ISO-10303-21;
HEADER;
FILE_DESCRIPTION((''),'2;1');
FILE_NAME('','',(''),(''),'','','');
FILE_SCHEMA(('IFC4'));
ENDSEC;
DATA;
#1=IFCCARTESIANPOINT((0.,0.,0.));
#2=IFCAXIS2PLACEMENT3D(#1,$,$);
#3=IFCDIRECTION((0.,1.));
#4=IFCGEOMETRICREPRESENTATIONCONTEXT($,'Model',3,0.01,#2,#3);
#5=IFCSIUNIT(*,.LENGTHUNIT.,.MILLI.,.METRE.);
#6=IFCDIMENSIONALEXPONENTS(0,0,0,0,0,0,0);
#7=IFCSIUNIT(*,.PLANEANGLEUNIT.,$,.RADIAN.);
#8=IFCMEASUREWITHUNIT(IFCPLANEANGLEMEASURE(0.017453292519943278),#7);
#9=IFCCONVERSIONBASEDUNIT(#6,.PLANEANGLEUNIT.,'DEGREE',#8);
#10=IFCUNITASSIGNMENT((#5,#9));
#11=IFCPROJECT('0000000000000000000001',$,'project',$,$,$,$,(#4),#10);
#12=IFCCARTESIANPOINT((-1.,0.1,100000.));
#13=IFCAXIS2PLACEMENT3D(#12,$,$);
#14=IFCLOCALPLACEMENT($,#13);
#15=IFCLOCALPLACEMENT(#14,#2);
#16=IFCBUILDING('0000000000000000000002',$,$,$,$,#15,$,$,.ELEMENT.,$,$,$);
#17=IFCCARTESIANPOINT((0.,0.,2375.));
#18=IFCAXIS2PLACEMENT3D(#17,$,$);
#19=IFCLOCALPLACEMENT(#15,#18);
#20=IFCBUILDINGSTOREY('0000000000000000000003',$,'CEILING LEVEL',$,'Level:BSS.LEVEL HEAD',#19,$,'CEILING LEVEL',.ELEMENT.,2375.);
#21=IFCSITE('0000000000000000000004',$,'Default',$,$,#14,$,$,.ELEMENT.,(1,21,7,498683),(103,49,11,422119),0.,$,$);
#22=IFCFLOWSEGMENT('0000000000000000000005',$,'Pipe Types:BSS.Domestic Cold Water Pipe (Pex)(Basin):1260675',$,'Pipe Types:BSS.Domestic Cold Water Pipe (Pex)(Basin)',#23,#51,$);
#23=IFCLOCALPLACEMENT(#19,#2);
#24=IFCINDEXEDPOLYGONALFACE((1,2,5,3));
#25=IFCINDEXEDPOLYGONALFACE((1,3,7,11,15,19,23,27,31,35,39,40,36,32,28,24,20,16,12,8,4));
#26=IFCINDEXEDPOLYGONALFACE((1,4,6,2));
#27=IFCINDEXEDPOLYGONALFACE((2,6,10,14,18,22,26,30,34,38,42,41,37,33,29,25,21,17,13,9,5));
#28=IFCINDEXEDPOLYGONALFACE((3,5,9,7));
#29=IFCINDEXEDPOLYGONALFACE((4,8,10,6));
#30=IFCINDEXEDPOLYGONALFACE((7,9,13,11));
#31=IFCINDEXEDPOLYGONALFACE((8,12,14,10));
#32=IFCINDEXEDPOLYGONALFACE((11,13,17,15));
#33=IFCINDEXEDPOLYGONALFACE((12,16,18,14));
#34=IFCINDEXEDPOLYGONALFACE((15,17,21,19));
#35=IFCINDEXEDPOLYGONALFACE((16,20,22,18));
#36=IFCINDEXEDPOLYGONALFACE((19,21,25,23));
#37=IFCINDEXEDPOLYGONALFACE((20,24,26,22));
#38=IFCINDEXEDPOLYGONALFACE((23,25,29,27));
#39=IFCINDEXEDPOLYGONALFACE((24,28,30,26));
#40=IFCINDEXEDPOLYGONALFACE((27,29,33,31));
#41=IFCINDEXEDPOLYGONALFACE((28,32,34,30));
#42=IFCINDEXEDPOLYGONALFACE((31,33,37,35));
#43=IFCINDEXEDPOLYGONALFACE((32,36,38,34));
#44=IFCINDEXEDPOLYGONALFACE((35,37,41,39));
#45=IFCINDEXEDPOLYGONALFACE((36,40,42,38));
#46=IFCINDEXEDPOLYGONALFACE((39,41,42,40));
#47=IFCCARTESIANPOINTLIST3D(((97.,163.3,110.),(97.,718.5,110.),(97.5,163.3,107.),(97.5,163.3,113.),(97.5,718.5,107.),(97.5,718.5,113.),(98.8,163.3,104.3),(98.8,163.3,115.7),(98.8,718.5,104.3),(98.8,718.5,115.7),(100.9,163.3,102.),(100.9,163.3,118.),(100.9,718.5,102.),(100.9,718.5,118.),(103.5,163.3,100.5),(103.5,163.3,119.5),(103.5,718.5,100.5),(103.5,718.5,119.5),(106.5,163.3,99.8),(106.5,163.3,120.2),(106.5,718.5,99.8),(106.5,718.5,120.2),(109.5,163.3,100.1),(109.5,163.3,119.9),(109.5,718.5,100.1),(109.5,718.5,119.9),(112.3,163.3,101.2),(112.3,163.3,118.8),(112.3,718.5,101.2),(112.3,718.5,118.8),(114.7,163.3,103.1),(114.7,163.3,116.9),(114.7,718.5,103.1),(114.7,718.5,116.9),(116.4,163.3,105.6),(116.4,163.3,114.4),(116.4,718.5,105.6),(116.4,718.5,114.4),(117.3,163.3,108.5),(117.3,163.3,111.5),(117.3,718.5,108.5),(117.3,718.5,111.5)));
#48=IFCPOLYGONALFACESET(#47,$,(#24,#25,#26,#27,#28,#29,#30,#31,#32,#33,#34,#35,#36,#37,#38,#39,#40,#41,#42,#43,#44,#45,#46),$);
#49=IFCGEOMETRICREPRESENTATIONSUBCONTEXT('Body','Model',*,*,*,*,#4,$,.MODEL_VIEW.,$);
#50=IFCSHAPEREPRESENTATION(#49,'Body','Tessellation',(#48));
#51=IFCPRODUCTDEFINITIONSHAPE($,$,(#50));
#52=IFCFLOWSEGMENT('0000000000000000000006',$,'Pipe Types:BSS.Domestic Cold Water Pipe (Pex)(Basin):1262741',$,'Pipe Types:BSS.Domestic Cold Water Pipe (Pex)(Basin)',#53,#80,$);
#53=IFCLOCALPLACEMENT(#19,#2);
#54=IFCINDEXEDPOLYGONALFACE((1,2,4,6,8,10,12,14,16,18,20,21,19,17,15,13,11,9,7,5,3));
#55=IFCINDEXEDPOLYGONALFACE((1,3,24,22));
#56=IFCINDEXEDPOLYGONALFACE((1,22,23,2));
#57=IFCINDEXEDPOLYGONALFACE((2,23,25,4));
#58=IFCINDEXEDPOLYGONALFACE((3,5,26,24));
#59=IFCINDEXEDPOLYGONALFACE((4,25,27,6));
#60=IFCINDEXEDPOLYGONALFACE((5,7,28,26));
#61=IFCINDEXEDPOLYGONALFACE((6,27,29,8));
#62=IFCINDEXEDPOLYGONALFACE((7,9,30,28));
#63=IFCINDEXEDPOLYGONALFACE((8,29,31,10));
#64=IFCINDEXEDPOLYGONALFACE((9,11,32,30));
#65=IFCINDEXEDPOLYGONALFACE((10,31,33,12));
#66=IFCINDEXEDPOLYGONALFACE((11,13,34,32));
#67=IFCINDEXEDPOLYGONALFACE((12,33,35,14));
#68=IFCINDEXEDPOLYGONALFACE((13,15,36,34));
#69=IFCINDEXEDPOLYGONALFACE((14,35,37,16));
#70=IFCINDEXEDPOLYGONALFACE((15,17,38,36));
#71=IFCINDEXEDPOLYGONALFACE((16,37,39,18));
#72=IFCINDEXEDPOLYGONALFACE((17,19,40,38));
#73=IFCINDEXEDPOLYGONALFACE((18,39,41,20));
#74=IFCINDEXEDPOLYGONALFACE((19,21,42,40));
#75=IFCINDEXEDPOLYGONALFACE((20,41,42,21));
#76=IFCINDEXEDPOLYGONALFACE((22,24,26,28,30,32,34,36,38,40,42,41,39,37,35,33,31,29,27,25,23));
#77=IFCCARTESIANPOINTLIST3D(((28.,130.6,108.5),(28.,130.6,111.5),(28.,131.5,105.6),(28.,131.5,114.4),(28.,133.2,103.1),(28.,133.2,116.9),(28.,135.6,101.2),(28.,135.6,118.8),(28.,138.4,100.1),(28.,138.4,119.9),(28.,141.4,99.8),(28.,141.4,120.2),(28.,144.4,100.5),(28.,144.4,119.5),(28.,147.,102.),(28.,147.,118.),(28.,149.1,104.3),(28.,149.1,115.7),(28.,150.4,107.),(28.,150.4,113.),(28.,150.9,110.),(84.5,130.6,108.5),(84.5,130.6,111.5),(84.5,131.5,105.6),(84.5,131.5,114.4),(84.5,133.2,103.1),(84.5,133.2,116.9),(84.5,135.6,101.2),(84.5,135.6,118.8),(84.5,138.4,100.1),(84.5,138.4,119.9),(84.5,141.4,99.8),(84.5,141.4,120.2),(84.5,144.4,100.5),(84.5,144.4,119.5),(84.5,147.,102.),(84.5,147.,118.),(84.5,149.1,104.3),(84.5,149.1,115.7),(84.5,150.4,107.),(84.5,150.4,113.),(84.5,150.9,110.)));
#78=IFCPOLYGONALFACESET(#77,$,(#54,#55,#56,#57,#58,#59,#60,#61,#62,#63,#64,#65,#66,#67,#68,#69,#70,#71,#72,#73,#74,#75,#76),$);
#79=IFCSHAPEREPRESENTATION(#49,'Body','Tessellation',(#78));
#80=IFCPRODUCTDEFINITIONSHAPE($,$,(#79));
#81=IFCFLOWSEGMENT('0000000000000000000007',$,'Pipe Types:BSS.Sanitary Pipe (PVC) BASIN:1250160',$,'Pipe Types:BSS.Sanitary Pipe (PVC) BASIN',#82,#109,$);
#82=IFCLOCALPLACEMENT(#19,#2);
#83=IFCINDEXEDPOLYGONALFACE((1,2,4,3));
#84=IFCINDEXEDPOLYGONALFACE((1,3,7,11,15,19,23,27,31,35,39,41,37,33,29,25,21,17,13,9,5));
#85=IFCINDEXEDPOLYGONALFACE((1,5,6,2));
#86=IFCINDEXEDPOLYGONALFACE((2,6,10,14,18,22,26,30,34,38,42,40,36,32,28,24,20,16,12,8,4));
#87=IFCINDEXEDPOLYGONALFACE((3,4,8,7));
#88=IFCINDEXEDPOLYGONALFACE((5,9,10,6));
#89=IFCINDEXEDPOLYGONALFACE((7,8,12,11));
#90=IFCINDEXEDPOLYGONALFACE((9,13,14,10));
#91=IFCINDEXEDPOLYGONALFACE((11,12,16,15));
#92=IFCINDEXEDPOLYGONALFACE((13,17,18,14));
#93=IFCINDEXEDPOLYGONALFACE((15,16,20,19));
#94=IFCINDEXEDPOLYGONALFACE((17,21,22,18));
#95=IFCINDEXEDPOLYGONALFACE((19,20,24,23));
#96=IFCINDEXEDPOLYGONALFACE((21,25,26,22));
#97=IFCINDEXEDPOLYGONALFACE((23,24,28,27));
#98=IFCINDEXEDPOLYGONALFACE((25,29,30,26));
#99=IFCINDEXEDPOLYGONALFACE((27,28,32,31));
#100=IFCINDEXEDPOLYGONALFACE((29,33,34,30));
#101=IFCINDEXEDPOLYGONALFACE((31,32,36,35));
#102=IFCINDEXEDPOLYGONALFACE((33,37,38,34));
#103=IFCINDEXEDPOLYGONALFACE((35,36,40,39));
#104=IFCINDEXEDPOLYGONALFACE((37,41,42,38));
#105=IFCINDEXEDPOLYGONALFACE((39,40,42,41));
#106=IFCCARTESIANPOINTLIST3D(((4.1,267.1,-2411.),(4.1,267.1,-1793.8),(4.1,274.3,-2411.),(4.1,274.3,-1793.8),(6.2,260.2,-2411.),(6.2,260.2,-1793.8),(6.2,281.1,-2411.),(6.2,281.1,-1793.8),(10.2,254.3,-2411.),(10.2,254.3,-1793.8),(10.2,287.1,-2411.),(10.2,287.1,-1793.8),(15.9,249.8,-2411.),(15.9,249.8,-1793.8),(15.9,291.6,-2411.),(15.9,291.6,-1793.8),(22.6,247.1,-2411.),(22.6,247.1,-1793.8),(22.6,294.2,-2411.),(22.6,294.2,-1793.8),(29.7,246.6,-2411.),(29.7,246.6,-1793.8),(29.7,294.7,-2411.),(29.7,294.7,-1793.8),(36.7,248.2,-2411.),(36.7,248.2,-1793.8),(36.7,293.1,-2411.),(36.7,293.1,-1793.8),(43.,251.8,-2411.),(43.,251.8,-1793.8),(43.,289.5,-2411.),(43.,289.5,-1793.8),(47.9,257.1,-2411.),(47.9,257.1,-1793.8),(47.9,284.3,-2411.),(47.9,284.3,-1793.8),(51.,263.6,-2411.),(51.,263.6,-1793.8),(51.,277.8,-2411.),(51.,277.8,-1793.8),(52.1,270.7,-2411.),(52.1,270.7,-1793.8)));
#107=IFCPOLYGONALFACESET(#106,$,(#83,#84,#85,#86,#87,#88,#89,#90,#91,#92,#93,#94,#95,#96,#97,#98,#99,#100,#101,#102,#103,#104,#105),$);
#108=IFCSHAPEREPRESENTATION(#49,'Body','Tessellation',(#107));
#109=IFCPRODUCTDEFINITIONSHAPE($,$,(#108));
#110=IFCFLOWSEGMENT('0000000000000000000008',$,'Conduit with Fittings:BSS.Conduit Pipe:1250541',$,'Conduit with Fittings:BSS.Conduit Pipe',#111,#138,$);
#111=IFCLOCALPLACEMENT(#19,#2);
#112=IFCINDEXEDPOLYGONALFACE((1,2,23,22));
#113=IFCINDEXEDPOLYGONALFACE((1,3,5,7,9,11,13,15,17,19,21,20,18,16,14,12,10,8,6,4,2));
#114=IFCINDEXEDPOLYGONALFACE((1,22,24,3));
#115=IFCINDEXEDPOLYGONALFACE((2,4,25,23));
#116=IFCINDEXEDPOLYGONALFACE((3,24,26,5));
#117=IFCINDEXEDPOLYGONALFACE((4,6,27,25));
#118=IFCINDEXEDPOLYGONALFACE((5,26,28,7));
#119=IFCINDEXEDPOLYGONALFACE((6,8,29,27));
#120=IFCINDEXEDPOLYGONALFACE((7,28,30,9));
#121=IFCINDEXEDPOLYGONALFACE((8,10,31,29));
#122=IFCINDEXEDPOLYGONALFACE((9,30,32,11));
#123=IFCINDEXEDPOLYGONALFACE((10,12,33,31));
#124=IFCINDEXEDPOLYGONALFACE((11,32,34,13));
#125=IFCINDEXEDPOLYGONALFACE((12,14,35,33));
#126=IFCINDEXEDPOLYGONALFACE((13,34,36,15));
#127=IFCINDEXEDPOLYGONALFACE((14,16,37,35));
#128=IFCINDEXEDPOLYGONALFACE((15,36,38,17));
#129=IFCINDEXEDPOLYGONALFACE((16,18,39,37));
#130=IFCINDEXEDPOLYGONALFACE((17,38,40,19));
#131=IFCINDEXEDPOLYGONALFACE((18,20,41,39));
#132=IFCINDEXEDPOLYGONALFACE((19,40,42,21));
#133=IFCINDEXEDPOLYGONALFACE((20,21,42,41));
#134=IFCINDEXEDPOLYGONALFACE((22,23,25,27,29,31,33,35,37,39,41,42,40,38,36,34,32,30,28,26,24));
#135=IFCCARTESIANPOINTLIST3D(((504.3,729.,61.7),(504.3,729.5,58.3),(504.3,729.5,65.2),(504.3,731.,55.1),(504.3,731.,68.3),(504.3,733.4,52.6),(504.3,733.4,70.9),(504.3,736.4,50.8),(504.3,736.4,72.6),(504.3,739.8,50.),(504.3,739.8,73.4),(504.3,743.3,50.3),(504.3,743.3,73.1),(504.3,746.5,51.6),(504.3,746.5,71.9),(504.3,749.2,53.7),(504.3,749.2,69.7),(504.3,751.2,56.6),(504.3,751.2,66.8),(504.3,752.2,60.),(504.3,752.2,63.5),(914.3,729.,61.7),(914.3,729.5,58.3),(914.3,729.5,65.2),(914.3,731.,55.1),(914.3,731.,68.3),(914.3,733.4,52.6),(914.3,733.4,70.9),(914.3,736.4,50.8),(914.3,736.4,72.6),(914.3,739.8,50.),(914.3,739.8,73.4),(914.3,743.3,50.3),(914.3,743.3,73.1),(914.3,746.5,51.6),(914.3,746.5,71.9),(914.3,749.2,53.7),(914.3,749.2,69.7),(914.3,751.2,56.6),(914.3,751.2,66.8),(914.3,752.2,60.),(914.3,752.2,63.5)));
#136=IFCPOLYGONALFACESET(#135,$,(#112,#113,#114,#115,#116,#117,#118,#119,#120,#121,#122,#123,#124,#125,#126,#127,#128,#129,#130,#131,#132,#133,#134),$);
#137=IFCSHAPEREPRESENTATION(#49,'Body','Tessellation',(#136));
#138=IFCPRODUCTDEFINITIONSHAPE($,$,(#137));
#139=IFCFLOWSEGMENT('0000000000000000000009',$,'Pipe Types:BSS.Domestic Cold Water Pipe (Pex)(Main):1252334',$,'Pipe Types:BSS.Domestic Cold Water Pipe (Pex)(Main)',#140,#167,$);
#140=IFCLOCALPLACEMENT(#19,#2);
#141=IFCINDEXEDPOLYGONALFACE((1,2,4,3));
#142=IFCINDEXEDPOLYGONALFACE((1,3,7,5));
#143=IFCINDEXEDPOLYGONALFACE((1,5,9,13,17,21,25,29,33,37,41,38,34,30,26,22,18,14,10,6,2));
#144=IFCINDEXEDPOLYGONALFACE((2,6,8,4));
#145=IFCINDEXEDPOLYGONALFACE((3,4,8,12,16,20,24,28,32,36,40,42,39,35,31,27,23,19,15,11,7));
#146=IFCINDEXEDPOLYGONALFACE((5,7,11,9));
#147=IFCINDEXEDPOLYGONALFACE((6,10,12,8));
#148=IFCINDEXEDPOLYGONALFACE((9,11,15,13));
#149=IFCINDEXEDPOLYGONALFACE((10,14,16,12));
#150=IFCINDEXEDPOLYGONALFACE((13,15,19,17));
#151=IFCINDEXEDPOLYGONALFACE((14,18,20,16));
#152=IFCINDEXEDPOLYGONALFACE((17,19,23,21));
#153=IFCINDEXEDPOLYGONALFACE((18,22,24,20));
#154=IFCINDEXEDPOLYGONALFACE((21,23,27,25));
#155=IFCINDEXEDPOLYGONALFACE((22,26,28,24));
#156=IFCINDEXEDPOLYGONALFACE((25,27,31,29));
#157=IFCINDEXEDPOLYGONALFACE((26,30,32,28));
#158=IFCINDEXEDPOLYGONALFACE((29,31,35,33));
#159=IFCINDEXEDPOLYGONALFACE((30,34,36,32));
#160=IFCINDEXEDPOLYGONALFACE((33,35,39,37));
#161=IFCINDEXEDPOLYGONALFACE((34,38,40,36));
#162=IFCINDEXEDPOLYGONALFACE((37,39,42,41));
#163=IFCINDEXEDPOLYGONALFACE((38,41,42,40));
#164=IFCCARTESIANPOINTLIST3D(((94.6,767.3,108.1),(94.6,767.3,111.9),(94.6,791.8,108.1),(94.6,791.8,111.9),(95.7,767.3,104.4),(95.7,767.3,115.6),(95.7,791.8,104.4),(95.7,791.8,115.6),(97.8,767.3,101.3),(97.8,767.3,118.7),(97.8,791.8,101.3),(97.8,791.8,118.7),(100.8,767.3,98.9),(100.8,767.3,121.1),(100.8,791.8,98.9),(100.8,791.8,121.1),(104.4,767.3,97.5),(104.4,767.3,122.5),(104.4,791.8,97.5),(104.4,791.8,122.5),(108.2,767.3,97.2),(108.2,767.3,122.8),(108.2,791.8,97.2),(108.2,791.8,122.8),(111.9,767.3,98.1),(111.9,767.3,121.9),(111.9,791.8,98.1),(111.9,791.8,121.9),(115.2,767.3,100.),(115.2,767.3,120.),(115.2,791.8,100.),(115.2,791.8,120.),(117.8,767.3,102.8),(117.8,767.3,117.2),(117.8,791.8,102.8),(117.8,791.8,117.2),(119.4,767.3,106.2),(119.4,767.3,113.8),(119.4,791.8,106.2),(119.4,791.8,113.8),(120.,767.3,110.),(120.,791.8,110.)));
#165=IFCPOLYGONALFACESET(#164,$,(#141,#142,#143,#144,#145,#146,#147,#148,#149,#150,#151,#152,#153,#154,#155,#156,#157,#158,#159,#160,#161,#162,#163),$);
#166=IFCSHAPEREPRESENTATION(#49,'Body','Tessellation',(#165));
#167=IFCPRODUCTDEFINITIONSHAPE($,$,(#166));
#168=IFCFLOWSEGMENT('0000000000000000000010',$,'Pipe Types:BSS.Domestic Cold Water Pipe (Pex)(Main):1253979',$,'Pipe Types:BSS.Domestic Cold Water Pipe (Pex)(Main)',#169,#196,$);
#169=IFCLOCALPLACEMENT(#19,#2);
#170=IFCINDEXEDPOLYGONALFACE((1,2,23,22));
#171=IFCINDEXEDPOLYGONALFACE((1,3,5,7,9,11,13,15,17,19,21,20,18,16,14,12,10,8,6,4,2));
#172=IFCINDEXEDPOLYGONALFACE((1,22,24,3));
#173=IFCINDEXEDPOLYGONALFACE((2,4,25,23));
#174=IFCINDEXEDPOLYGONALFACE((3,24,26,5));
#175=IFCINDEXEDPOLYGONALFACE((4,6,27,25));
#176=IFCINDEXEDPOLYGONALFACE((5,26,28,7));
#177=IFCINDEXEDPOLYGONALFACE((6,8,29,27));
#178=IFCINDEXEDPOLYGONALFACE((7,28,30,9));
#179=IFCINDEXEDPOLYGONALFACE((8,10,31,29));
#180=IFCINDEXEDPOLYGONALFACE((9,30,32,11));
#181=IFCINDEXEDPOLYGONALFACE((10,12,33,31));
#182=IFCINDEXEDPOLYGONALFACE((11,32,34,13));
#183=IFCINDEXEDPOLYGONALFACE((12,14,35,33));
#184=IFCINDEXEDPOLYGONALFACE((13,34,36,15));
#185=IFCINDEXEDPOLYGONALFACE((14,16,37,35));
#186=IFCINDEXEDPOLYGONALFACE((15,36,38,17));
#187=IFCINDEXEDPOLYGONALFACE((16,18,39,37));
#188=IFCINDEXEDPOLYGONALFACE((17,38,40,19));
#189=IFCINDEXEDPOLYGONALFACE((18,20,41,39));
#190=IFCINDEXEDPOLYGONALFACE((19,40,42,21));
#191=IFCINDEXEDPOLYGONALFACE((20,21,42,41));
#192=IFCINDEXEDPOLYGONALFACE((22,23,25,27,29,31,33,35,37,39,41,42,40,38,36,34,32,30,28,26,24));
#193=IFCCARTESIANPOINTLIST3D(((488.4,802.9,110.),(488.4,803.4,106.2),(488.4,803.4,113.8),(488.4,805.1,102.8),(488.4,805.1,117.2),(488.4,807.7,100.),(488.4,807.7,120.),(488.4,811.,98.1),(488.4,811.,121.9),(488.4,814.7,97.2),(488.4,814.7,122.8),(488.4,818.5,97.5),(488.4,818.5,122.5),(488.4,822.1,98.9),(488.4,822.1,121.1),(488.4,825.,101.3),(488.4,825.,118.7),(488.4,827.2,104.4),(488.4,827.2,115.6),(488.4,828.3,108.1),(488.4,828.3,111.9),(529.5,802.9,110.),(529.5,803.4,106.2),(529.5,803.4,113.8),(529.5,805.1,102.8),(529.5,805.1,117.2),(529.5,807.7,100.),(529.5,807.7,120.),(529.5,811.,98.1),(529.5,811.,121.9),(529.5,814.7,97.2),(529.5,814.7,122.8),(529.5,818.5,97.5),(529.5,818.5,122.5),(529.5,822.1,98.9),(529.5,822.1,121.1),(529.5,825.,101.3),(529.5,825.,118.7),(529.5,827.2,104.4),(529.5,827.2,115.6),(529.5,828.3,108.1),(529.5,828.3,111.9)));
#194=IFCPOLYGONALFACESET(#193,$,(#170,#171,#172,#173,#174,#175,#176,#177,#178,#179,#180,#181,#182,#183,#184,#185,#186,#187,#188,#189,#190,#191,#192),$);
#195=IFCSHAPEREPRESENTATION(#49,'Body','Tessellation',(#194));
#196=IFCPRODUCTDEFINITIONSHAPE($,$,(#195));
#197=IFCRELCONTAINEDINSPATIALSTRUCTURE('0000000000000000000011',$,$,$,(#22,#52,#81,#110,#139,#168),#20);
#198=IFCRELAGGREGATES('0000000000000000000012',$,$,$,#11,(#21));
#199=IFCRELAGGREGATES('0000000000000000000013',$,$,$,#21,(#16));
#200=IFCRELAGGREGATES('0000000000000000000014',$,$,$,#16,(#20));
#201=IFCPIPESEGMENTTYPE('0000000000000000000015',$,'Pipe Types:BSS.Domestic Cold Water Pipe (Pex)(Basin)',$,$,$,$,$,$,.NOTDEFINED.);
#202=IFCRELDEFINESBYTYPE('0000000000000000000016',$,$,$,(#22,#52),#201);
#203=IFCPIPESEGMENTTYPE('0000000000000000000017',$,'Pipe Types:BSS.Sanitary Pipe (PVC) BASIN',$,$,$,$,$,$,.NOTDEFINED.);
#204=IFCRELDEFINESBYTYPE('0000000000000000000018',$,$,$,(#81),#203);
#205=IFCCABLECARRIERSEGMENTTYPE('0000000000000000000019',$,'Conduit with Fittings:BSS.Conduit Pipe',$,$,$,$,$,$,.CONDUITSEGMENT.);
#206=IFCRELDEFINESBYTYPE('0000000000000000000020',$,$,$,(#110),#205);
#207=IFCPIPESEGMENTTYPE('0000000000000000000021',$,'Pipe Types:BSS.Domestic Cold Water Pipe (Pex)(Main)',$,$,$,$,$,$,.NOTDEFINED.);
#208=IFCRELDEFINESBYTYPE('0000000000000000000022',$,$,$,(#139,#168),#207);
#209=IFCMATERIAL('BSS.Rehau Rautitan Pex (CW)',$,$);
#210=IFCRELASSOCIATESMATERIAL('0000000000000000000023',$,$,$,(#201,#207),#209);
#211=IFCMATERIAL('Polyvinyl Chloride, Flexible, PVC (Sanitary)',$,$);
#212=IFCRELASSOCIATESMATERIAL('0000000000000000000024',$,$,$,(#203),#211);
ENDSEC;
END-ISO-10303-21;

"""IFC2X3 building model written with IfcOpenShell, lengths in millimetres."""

from ifc_helpers import new_model, entity, si_unit, converted_unit, direction, frame, frame_2d, origin, place, context, subcontext, project, spatial, circle, extrude, material, type_object, element, save


model = new_model("IFC2X3")

# Units and contexts
model_context = context("Model", 3, precision=0.01, world=origin(), true_north=direction((0.0, 1.0)))
body_context = subcontext(model_context, "Body", "Model", "MODEL_VIEW")
ifc_project = project(units=[si_unit("LENGTHUNIT", "METRE", prefix="MILLI"), converted_unit("PLANEANGLEUNIT", "DEGREE", entity("IfcPlaneAngleMeasure", 0.017453292519943278), si_unit("PLANEANGLEUNIT", "RADIAN"), dimensions=[0, 0, 0, 0, 0, 0, 0])], contexts=[model_context])

# Site, building, storey
site_placement = place(None, frame((-1.0, 0.1, 100000.0)))
site = spatial("IfcSite", under=ifc_project, at=site_placement, Name="Default", CompositionType="ELEMENT", RefLatitude=(1, 21, 7, 498683), RefLongitude=(103, 49, 11, 422119), RefElevation=0.0)
building_placement = place(site_placement, origin())
building = spatial("IfcBuilding", under=site, at=building_placement, CompositionType="ELEMENT")
storey_placement = place(building_placement, frame((0.0, 0.0, 2375.0)))
storey = spatial("IfcBuildingStorey", under=building, at=storey_placement, Name="CEILING LEVEL", ObjectType="Level:BSS.LEVEL HEAD", LongName="CEILING LEVEL", CompositionType="ELEMENT", Elevation=2375.0)

# Flow segments
ifc_material_1 = material(Name="BSS.Rehau Rautitan Pex (CW)")
pipe_segment_type_1 = type_object("IfcPipeSegmentType", Name="Pipe Types:BSS.Domestic Cold Water Pipe (Pex)(Basin)", PredefinedType="NOTDEFINED", material=ifc_material_1)
flow_segment_1_placement = place(storey_placement, origin())
element("IfcFlowSegment", 1, at=flow_segment_1_placement, inside=storey, type_object=pipe_segment_type_1, Name="Pipe Types:BSS.Domestic Cold Water Pipe (Pex)(Basin):1260675", ObjectType="Pipe Types:BSS.Domestic Cold Water Pipe (Pex)(Basin)", context=body_context, shape_type="SweptSolid", body=[
    extrude(circle(Radius=10.2, at=frame_2d((0.0, 0.0), x_axis=(1.0, 0.0))), frame((107.2, 163.3, 110.0), z_axis=(0.0, 1.0, 0.0), x_axis=(-1.0, 0.0, 0.0)), (0.0, 0.0, 1.0), 555.2),
])
flow_segment_2_placement = place(storey_placement, origin())
element("IfcFlowSegment", 2, at=flow_segment_2_placement, inside=storey, type_object=pipe_segment_type_1, Name="Pipe Types:BSS.Domestic Cold Water Pipe (Pex)(Basin):1262741", ObjectType="Pipe Types:BSS.Domestic Cold Water Pipe (Pex)(Basin)", context=body_context, shape_type="SweptSolid", body=[
    extrude(circle(Radius=10.2, at=frame_2d((0.0, 0.0), x_axis=(1.0, 0.0))), frame((28.0, 140.7, 110.0), z_axis=(1.0, 0.0, 0.0), x_axis=(0.0, 1.0, 0.0)), (0.0, 0.0, 1.0), 56.5),
])
ifc_material_2 = material(Name="Polyvinyl Chloride, Flexible, PVC (Sanitary)")
pipe_segment_type_2 = type_object("IfcPipeSegmentType", Name="Pipe Types:BSS.Sanitary Pipe (PVC) BASIN", PredefinedType="NOTDEFINED", material=ifc_material_2)
flow_segment_3_placement = place(storey_placement, origin())
element("IfcFlowSegment", 3, at=flow_segment_3_placement, inside=storey, type_object=pipe_segment_type_2, Name="Pipe Types:BSS.Sanitary Pipe (PVC) BASIN:1250160", ObjectType="Pipe Types:BSS.Sanitary Pipe (PVC) BASIN", context=body_context, shape_type="SweptSolid", body=[
    extrude(circle(Radius=24.1, at=frame_2d((0.0, 0.0), x_axis=(1.0, 0.0))), frame((27.9, 270.7, -2411.0)), (0.0, 0.0, 1.0), 617.2),
])
cable_carrier_segment_type = type_object("IfcCableCarrierSegmentType", Name="Conduit with Fittings:BSS.Conduit Pipe", PredefinedType="CONDUITSEGMENT")
flow_segment_4_placement = place(storey_placement, origin())
element("IfcFlowSegment", 4, at=flow_segment_4_placement, inside=storey, type_object=cable_carrier_segment_type, Name="Conduit with Fittings:BSS.Conduit Pipe:1250541", ObjectType="Conduit with Fittings:BSS.Conduit Pipe", context=body_context, shape_type="SweptSolid", body=[
    extrude(circle(Radius=11.7, at=frame_2d((0.0, 0.0), x_axis=(1.0, 0.0))), frame((504.3, 740.7, 61.7), z_axis=(1.0, 0.0, 0.0), x_axis=(0.0, -1.0, 0.0)), (0.0, 0.0, 1.0), 410.0),
])
pipe_segment_type_3 = type_object("IfcPipeSegmentType", Name="Pipe Types:BSS.Domestic Cold Water Pipe (Pex)(Main)", PredefinedType="NOTDEFINED", material=ifc_material_1)
flow_segment_5_placement = place(storey_placement, origin())
element("IfcFlowSegment", 5, at=flow_segment_5_placement, inside=storey, type_object=pipe_segment_type_3, Name="Pipe Types:BSS.Domestic Cold Water Pipe (Pex)(Main):1252334", ObjectType="Pipe Types:BSS.Domestic Cold Water Pipe (Pex)(Main)", context=body_context, shape_type="SweptSolid", body=[
    extrude(circle(Radius=12.8, at=frame_2d((0.0, 0.0), x_axis=(1.0, 0.0))), frame((107.2, 767.3, 110.0), z_axis=(0.0, 1.0, 0.0), x_axis=(1.0, 0.0, 0.0)), (0.0, 0.0, 1.0), 24.5),
])
flow_segment_6_placement = place(storey_placement, origin())
element("IfcFlowSegment", 6, at=flow_segment_6_placement, inside=storey, type_object=pipe_segment_type_3, Name="Pipe Types:BSS.Domestic Cold Water Pipe (Pex)(Main):1253979", ObjectType="Pipe Types:BSS.Domestic Cold Water Pipe (Pex)(Main)", context=body_context, shape_type="SweptSolid", body=[
    extrude(circle(Radius=12.8, at=frame_2d((0.0, 0.0), x_axis=(1.0, 0.0))), frame((488.4, 815.7, 110.0), z_axis=(1.0, 0.0, 0.0), x_axis=(0.0, -1.0, 0.0)), (0.0, 0.0, 1.0), 41.1),
])

save(model, "model.ifc")
